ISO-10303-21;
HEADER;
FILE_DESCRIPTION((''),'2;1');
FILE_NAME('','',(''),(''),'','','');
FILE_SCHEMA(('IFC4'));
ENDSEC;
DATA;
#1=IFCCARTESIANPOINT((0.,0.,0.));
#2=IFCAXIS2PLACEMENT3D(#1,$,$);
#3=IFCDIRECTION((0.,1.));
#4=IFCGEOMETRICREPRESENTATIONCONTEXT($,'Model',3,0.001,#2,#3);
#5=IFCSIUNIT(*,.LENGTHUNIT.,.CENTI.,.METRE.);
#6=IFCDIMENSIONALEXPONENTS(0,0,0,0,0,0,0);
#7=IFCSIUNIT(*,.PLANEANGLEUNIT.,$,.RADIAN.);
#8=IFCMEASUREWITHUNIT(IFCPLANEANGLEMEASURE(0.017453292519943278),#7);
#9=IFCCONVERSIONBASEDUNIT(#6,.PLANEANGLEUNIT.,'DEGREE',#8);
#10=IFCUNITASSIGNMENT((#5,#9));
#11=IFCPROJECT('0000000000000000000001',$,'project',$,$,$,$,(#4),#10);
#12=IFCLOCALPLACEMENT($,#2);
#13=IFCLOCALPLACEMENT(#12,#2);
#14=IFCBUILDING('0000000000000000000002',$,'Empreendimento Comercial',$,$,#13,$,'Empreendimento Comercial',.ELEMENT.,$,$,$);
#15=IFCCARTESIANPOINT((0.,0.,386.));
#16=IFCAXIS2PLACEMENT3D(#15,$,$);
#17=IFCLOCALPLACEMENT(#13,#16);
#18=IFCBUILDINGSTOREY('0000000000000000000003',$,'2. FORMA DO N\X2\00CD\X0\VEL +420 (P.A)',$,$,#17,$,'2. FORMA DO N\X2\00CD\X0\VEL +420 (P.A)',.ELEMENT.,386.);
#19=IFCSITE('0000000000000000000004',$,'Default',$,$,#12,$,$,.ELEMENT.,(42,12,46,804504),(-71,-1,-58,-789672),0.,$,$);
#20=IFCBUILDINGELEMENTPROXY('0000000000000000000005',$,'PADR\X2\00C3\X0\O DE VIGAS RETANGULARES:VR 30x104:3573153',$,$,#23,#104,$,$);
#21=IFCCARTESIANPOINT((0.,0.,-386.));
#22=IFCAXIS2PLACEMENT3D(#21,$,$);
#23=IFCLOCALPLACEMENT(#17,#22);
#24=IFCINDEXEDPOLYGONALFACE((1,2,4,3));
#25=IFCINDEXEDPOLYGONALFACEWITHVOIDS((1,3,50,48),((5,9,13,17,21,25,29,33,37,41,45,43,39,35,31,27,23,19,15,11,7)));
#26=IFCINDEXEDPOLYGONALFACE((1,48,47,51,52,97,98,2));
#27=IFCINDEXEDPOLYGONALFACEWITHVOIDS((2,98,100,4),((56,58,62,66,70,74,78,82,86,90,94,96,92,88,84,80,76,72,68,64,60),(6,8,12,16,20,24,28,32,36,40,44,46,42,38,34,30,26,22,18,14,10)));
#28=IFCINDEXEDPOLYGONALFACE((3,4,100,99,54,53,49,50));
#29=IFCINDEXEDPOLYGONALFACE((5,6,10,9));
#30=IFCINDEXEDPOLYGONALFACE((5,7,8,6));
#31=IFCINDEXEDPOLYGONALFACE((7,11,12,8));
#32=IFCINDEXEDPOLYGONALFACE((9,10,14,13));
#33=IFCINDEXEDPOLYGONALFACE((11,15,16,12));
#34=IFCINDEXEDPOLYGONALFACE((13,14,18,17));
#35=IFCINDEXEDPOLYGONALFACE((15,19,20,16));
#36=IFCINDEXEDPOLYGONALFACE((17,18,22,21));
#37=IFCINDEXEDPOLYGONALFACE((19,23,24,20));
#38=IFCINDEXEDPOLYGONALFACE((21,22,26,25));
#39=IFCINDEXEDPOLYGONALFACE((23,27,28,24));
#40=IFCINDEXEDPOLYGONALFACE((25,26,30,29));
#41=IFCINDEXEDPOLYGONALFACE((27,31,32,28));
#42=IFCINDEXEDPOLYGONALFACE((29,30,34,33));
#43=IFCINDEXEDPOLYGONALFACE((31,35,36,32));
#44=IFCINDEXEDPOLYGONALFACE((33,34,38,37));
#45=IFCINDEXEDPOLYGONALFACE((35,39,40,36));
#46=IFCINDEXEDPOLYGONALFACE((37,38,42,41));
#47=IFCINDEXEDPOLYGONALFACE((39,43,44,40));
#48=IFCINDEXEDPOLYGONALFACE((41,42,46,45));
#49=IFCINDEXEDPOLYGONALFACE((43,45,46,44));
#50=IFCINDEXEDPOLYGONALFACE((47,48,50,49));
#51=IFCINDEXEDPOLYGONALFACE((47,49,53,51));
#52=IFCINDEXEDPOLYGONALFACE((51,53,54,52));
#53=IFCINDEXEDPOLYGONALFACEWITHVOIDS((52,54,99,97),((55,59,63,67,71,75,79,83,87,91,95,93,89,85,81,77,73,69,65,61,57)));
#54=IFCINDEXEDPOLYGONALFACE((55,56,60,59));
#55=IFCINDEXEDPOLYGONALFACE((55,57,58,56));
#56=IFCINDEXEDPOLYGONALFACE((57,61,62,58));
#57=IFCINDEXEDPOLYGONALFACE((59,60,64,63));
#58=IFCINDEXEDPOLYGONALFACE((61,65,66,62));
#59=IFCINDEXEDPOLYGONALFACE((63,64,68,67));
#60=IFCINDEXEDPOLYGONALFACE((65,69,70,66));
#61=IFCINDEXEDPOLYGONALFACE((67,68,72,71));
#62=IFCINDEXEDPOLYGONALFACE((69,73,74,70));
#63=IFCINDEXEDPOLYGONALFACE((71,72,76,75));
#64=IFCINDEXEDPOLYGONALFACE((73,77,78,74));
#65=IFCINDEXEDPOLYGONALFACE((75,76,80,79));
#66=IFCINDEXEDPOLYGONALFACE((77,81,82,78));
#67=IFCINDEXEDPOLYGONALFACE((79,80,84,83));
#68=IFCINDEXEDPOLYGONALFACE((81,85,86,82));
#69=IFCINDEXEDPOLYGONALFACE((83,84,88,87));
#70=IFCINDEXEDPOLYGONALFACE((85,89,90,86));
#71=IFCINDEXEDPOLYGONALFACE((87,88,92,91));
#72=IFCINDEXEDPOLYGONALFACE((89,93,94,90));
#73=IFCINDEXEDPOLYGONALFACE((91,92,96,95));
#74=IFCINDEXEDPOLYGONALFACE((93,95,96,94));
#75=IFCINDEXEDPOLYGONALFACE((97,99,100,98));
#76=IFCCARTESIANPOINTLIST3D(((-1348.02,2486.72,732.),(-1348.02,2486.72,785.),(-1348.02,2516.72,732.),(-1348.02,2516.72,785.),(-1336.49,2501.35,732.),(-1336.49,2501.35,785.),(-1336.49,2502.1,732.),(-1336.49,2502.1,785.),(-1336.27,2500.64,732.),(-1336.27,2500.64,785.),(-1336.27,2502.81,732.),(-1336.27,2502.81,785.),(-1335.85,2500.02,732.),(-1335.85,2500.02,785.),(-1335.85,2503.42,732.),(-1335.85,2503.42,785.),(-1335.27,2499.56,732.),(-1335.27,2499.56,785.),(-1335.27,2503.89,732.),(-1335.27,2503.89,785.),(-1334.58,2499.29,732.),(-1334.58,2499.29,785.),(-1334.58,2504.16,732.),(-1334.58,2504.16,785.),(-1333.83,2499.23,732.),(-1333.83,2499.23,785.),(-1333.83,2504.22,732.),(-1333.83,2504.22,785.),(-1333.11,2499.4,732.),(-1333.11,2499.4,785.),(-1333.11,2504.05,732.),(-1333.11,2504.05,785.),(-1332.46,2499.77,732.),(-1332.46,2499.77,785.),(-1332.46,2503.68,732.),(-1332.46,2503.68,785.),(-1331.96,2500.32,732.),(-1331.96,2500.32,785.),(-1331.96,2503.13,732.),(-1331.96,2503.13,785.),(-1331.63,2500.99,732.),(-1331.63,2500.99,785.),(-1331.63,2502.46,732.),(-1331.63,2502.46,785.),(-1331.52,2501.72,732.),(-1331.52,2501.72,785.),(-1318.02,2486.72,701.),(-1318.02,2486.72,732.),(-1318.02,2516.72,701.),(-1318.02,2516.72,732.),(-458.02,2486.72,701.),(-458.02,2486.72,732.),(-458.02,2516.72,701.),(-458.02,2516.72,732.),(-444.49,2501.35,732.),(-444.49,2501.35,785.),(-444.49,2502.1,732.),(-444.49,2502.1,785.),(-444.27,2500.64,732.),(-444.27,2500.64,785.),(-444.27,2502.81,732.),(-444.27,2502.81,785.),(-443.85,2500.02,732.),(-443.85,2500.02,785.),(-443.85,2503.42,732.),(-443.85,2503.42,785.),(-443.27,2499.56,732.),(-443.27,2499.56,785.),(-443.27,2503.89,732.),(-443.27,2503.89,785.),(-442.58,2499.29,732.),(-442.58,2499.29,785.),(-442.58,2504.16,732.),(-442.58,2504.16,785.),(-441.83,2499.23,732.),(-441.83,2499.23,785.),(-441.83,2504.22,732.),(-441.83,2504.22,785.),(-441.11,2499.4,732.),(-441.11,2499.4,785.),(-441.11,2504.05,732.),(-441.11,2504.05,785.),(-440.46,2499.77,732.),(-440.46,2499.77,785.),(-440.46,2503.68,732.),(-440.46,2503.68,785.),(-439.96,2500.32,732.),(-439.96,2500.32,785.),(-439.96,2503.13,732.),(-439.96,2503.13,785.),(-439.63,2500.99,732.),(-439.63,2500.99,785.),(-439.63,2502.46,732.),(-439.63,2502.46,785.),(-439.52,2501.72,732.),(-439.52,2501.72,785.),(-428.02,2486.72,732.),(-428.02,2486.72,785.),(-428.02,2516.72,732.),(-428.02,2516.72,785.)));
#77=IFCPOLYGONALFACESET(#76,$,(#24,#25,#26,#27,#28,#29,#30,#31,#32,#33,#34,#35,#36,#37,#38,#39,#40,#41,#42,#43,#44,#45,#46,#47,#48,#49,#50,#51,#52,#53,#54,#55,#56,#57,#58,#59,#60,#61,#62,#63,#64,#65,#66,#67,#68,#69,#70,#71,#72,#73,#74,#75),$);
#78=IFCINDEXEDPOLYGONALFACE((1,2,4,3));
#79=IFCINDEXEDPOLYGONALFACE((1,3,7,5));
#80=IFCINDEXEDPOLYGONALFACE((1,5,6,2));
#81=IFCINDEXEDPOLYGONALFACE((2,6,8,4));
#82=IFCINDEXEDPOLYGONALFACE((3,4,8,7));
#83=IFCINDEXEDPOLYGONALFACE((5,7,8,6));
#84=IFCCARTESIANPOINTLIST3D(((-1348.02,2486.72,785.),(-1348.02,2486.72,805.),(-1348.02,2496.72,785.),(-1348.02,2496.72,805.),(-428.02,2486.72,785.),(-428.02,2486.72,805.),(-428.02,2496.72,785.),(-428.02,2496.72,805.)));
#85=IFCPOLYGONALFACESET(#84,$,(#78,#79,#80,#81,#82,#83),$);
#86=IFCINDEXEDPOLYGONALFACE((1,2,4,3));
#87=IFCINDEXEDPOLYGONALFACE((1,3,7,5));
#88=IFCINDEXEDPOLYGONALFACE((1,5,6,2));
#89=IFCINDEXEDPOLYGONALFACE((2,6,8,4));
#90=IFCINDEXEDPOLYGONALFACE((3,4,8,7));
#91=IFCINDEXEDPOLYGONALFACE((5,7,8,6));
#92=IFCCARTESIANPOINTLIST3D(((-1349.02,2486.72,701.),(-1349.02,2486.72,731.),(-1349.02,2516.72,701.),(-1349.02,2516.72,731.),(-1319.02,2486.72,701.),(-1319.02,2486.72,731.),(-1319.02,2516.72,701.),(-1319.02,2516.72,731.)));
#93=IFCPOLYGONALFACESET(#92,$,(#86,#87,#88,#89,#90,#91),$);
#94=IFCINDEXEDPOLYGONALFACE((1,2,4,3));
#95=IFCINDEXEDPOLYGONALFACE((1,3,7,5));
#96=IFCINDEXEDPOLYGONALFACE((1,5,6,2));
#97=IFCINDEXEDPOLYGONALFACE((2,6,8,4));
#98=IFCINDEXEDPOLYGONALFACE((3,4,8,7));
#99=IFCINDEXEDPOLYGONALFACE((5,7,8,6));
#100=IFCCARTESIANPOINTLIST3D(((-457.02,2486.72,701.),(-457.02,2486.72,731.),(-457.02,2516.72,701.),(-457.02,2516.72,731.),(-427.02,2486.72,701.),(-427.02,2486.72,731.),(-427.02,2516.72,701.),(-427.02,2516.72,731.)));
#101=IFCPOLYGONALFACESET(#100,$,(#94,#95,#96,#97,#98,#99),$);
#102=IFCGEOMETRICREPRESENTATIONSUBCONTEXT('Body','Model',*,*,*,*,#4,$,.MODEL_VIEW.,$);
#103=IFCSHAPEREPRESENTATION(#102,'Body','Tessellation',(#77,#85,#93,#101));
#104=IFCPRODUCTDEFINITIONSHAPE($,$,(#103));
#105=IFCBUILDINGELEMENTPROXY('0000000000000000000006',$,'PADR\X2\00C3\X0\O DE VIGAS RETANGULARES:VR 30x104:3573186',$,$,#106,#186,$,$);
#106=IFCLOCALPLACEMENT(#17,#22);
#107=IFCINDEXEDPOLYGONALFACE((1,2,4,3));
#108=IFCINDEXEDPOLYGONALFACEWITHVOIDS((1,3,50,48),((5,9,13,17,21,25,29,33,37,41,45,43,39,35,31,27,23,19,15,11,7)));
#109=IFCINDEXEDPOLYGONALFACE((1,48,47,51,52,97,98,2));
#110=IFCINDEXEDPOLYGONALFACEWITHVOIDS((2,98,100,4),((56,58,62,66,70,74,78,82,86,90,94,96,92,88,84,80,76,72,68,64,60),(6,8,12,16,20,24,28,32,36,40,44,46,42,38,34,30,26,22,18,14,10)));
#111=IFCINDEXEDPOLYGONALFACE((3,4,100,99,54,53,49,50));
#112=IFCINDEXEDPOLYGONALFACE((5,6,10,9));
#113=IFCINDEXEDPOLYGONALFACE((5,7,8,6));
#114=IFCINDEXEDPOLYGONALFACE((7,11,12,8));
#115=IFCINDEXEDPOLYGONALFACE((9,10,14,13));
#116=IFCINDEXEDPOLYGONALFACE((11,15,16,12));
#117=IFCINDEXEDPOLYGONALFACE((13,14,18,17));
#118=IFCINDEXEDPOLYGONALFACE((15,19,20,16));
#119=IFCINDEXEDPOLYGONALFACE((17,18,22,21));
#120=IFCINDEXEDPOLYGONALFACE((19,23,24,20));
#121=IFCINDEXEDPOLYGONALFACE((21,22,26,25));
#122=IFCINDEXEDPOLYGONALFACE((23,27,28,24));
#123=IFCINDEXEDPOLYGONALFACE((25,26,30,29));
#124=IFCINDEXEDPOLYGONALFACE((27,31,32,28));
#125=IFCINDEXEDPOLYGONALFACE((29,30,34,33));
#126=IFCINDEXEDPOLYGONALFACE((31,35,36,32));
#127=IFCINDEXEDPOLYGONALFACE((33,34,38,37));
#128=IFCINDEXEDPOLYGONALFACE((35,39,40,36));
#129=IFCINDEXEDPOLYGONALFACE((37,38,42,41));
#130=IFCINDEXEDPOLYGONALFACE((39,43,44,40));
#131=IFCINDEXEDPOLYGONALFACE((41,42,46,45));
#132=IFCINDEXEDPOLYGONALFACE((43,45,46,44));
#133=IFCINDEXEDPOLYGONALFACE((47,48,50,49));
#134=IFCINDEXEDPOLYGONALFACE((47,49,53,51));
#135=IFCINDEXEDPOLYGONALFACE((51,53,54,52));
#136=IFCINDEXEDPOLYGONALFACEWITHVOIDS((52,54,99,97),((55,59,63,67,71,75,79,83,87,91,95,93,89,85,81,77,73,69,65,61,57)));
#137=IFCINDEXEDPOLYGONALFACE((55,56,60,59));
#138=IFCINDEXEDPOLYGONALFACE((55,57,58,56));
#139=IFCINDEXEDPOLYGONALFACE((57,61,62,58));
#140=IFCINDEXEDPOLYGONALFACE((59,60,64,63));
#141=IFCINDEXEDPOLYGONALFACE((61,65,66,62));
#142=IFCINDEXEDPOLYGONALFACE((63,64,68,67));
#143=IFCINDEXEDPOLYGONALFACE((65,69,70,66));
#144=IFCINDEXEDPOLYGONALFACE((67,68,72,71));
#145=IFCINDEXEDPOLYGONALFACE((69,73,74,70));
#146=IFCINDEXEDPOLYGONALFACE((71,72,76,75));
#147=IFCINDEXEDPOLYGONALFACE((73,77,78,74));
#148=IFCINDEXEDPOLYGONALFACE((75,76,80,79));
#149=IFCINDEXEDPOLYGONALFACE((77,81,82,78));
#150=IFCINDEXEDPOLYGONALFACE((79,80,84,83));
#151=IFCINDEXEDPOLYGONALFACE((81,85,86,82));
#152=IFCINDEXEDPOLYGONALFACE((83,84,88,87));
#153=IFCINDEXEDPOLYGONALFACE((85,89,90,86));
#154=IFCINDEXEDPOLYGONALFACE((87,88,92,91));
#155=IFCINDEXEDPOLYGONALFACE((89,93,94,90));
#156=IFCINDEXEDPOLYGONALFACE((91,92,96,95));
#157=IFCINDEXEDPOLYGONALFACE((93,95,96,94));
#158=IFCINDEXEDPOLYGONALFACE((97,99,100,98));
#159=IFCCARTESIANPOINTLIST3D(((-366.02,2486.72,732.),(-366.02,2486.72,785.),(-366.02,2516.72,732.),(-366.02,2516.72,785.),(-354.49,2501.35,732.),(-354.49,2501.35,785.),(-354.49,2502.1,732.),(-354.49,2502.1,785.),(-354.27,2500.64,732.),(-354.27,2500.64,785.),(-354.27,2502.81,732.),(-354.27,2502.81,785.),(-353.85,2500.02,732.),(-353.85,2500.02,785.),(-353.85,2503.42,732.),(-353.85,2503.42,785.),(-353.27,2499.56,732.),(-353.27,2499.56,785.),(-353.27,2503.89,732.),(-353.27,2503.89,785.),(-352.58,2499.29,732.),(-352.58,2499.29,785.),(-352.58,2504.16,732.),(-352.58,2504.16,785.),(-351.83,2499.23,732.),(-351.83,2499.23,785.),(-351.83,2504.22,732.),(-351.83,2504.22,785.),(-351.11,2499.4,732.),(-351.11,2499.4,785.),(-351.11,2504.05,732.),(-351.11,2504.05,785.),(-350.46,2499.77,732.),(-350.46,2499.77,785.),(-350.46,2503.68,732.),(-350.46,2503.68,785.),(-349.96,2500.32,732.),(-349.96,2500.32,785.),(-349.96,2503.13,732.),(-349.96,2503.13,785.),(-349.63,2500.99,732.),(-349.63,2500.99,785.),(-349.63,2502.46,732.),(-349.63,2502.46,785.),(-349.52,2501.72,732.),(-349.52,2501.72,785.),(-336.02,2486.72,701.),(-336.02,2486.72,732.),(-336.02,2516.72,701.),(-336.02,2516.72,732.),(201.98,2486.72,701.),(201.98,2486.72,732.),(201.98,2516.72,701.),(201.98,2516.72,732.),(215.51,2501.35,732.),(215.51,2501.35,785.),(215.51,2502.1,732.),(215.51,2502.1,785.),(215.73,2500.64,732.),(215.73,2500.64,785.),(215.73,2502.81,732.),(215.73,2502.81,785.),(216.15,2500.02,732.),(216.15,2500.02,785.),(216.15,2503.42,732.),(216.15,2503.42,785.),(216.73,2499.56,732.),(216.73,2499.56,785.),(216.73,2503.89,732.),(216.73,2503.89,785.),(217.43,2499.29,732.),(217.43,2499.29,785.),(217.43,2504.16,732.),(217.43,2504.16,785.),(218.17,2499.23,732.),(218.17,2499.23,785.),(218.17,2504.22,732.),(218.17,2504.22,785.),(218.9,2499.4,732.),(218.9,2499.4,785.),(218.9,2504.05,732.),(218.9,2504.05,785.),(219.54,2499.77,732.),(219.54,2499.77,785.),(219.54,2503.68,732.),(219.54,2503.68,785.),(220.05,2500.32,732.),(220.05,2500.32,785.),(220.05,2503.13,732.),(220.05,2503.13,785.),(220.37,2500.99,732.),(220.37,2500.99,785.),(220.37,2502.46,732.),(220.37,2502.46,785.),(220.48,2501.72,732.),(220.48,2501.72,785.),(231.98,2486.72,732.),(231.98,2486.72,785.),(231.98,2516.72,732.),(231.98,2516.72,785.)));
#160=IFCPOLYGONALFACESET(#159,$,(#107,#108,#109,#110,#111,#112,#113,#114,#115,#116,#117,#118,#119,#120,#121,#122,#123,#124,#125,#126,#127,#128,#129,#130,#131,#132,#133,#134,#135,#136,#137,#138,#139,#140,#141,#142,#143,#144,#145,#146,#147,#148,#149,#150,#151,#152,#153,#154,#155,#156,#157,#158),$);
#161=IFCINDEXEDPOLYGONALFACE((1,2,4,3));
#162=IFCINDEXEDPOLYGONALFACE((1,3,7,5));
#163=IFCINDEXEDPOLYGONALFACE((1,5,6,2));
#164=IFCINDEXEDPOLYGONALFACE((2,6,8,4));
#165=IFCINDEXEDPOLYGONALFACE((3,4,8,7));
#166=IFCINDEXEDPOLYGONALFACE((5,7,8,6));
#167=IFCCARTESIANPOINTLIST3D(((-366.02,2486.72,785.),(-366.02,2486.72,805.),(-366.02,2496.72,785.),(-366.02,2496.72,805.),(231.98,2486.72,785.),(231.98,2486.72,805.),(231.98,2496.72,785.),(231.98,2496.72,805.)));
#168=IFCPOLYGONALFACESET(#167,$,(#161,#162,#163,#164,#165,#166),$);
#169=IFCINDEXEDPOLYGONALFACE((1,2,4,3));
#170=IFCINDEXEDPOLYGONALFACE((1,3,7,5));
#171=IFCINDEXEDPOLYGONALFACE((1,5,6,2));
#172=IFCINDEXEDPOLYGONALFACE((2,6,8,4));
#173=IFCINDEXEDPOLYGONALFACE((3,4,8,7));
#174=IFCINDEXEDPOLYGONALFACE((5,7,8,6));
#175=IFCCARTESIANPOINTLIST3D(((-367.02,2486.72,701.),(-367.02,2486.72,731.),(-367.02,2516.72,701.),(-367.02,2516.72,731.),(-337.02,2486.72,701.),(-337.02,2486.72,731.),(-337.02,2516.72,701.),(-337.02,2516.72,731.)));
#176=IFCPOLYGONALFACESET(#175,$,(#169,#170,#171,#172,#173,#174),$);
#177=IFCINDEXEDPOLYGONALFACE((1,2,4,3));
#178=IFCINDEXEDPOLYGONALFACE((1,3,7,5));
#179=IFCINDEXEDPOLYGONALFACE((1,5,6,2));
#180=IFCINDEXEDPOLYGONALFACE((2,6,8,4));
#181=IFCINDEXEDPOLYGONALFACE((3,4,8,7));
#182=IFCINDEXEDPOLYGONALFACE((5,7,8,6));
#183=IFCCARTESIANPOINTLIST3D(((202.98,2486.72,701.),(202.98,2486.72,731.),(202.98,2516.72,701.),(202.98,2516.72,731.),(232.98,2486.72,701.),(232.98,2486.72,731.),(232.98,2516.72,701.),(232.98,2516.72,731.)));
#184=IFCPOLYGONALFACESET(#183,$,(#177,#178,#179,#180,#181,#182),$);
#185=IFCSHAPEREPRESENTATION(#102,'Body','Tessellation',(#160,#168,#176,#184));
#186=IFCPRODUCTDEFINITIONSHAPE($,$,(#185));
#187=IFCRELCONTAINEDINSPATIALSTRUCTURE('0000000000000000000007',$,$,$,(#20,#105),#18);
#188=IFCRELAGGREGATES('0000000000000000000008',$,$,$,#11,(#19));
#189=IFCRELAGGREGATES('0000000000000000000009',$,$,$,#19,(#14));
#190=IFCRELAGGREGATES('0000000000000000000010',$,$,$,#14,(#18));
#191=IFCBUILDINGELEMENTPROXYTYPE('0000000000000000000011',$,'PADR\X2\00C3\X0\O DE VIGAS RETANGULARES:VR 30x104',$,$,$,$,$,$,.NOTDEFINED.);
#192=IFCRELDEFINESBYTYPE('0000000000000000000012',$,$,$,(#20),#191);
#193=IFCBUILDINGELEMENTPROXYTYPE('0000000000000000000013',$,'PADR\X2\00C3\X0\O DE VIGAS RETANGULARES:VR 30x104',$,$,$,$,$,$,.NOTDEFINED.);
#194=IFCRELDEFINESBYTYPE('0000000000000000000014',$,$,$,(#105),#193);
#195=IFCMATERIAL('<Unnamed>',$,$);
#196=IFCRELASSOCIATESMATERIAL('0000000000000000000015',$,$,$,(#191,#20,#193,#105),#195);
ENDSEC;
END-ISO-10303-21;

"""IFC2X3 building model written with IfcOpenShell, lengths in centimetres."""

from ifc_helpers import new_model, entity, si_unit, converted_unit, direction, frame, frame_2d, origin, origin_2d_with_axis, place, context, subcontext, project, spatial, polyline, rectangle, circle, outline, extrude, source, transform, mapped, material, type_object, type_shapes, element, save


model = new_model("IFC2X3")

# Units and contexts
model_context = context("Model", 3, precision=0.001, world=origin(), true_north=direction((0.0, 1.0)))
body_context = subcontext(model_context, "Body", "Model", "MODEL_VIEW")
ifc_project = project(units=[si_unit("LENGTHUNIT", "METRE", prefix="CENTI"), converted_unit("PLANEANGLEUNIT", "DEGREE", entity("IfcPlaneAngleMeasure", 0.017453292519943278), si_unit("PLANEANGLEUNIT", "RADIAN"), dimensions=[0, 0, 0, 0, 0, 0, 0])], contexts=[model_context])

# Site, building, storey
site_placement = place(None, origin())
site = spatial("IfcSite", under=ifc_project, at=site_placement, Name="Default", CompositionType="ELEMENT", RefLatitude=(42, 12, 46, 804504), RefLongitude=(-71, -1, -58, -789672), RefElevation=0.0)
building_placement = place(site_placement, origin())
building = spatial("IfcBuilding", under=site, at=building_placement, Name="Empreendimento Comercial", LongName="Empreendimento Comercial", CompositionType="ELEMENT")
storey_placement = place(building_placement, frame((0.0, 0.0, 386.0)))
storey = spatial("IfcBuildingStorey", under=building, at=storey_placement, Name="2. FORMA DO NÍVEL +420 (P.A)", LongName="2. FORMA DO NÍVEL +420 (P.A)", CompositionType="ELEMENT", Elevation=386.0)

# Shared definitions
ifc_material_1 = material(Name="<Unnamed>")

# Building element proxies, openings
building_element_proxy_type_1 = type_object("IfcBuildingElementProxyType", Name="PADRÃO DE VIGAS RETANGULARES:VR 30x104", PredefinedType="NOTDEFINED", material=ifc_material_1)
shared_shape_1 = source(origin(), body_context, "Body", "SweptSolid", [
    extrude(outline(polyline([(-460.0, -47.5), (460.0, -47.5), (460.0, 5.5), (430.0, 5.5), (430.0, 36.5), (-430.0, 36.5), (-430.0, 5.5), (-460.0, 5.5), (-460.0, -47.5)])), frame((-888.02, 2486.72, 737.5), z_axis=(0.0, 1.0, 0.0), x_axis=(1.0, 0.0, 0.0)), (0.0, 0.0, 1.0), 30.0),
    extrude(rectangle(XDim=10.0, YDim=920.0, at=frame_2d((0.0, 0.0), x_axis=(1.0, 0.0))), frame((-888.02, 2491.72, 785.0), z_axis=(0.0, 0.0, 1.0), x_axis=(0.0, 1.0, 0.0)), (0.0, 0.0, 1.0), 20.0),
    extrude(rectangle(XDim=30.0, YDim=30.0, at=frame_2d((0.0, 0.0), x_axis=(1.0, 0.0))), frame((-1334.02, 2501.72, 701.0), z_axis=(0.0, 0.0, 1.0), x_axis=(-1.0, 0.0, 0.0)), (0.0, 0.0, 1.0), 30.0),
    extrude(rectangle(XDim=30.0, YDim=30.0, at=origin_2d_with_axis()), frame((-442.02, 2501.72, 701.0), z_axis=(0.0, 0.0, 1.0), x_axis=(-1.0, 0.0, 0.0)), (0.0, 0.0, 1.0), 30.0),
])
type_shapes(building_element_proxy_type_1, [shared_shape_1])
proxy_1_placement = place(storey_placement, frame((0.0, 0.0, -386.0)))
proxy_1 = element("IfcBuildingElementProxy", 1, at=proxy_1_placement, inside=storey, type_object=building_element_proxy_type_1, material=ifc_material_1, Name="PADRÃO DE VIGAS RETANGULARES:VR 30x104:3573153", context=body_context, shape_type="MappedRepresentation", body=[
    mapped(shared_shape_1, transform((0.0, 0.0, 0.0), scale=1.0)),
])
opening_1_placement = place(storey_placement, frame((0.0, 0.0, -386.0)))
element("IfcOpeningElement", 2, at=opening_1_placement, cuts=proxy_1, ObjectType="Opening", context=body_context, shape_type="SweptSolid", body=[
    extrude(circle(Radius=2.5, at=origin_2d_with_axis()), frame((-442.02, 2501.72, 732.0)), (0.0, 0.0, 1.0), 53.0),
])
opening_2_placement = place(storey_placement, frame((0.0, 0.0, -386.0)))
element("IfcOpeningElement", 3, at=opening_2_placement, cuts=proxy_1, ObjectType="Opening", context=body_context, shape_type="SweptSolid", body=[
    extrude(circle(Radius=2.5, at=origin_2d_with_axis()), frame((-1334.02, 2501.72, 732.0)), (0.0, 0.0, 1.0), 53.0),
])
building_element_proxy_type_2 = type_object("IfcBuildingElementProxyType", Name="PADRÃO DE VIGAS RETANGULARES:VR 30x104", PredefinedType="NOTDEFINED", material=ifc_material_1)
shared_shape_2 = source(origin(), body_context, "Body", "SweptSolid", [
    extrude(outline(polyline([(-299.0, -47.5), (299.0, -47.5), (299.0, 5.5), (269.0, 5.5), (269.0, 36.5), (-269.0, 36.5), (-269.0, 5.5), (-299.0, 5.5), (-299.0, -47.5)])), frame((-67.02, 2486.72, 737.5), z_axis=(0.0, 1.0, 0.0), x_axis=(1.0, 0.0, 0.0)), (0.0, 0.0, 1.0), 30.0),
    extrude(rectangle(XDim=10.0, YDim=598.0, at=frame_2d((0.0, 0.0), x_axis=(1.0, 0.0))), frame((-67.02, 2491.72, 785.0), z_axis=(0.0, 0.0, 1.0), x_axis=(0.0, 1.0, 0.0)), (0.0, 0.0, 1.0), 20.0),
    extrude(rectangle(XDim=30.0, YDim=30.0, at=frame_2d((0.0, 0.0), x_axis=(1.0, 0.0))), frame((-352.02, 2501.72, 701.0), z_axis=(0.0, 0.0, 1.0), x_axis=(-1.0, 0.0, 0.0)), (0.0, 0.0, 1.0), 30.0),
    extrude(rectangle(XDim=30.0, YDim=30.0, at=frame_2d((0.0, 0.0), x_axis=(1.0, 0.0))), frame((217.98, 2501.72, 701.0), z_axis=(0.0, 0.0, 1.0), x_axis=(-1.0, 0.0, 0.0)), (0.0, 0.0, 1.0), 30.0),
])
type_shapes(building_element_proxy_type_2, [shared_shape_2])
proxy_2_placement = place(storey_placement, frame((0.0, 0.0, -386.0)))
proxy_2 = element("IfcBuildingElementProxy", 4, at=proxy_2_placement, inside=storey, type_object=building_element_proxy_type_2, material=ifc_material_1, Name="PADRÃO DE VIGAS RETANGULARES:VR 30x104:3573186", context=body_context, shape_type="MappedRepresentation", body=[
    mapped(shared_shape_2, transform((0.0, 0.0, 0.0), scale=1.0)),
])
opening_3_placement = place(storey_placement, frame((0.0, 0.0, -386.0)))
element("IfcOpeningElement", 5, at=opening_3_placement, cuts=proxy_2, ObjectType="Opening", context=body_context, shape_type="SweptSolid", body=[
    extrude(circle(Radius=2.5, at=origin_2d_with_axis()), frame((217.98, 2501.72, 732.0)), (0.0, 0.0, 1.0), 53.0),
])
opening_4_placement = place(storey_placement, frame((0.0, 0.0, -386.0)))
element("IfcOpeningElement", 6, at=opening_4_placement, cuts=proxy_2, ObjectType="Opening", context=body_context, shape_type="SweptSolid", body=[
    extrude(circle(Radius=2.5, at=origin_2d_with_axis()), frame((-352.02, 2501.72, 732.0)), (0.0, 0.0, 1.0), 53.0),
])

save(model, "model.ifc")
